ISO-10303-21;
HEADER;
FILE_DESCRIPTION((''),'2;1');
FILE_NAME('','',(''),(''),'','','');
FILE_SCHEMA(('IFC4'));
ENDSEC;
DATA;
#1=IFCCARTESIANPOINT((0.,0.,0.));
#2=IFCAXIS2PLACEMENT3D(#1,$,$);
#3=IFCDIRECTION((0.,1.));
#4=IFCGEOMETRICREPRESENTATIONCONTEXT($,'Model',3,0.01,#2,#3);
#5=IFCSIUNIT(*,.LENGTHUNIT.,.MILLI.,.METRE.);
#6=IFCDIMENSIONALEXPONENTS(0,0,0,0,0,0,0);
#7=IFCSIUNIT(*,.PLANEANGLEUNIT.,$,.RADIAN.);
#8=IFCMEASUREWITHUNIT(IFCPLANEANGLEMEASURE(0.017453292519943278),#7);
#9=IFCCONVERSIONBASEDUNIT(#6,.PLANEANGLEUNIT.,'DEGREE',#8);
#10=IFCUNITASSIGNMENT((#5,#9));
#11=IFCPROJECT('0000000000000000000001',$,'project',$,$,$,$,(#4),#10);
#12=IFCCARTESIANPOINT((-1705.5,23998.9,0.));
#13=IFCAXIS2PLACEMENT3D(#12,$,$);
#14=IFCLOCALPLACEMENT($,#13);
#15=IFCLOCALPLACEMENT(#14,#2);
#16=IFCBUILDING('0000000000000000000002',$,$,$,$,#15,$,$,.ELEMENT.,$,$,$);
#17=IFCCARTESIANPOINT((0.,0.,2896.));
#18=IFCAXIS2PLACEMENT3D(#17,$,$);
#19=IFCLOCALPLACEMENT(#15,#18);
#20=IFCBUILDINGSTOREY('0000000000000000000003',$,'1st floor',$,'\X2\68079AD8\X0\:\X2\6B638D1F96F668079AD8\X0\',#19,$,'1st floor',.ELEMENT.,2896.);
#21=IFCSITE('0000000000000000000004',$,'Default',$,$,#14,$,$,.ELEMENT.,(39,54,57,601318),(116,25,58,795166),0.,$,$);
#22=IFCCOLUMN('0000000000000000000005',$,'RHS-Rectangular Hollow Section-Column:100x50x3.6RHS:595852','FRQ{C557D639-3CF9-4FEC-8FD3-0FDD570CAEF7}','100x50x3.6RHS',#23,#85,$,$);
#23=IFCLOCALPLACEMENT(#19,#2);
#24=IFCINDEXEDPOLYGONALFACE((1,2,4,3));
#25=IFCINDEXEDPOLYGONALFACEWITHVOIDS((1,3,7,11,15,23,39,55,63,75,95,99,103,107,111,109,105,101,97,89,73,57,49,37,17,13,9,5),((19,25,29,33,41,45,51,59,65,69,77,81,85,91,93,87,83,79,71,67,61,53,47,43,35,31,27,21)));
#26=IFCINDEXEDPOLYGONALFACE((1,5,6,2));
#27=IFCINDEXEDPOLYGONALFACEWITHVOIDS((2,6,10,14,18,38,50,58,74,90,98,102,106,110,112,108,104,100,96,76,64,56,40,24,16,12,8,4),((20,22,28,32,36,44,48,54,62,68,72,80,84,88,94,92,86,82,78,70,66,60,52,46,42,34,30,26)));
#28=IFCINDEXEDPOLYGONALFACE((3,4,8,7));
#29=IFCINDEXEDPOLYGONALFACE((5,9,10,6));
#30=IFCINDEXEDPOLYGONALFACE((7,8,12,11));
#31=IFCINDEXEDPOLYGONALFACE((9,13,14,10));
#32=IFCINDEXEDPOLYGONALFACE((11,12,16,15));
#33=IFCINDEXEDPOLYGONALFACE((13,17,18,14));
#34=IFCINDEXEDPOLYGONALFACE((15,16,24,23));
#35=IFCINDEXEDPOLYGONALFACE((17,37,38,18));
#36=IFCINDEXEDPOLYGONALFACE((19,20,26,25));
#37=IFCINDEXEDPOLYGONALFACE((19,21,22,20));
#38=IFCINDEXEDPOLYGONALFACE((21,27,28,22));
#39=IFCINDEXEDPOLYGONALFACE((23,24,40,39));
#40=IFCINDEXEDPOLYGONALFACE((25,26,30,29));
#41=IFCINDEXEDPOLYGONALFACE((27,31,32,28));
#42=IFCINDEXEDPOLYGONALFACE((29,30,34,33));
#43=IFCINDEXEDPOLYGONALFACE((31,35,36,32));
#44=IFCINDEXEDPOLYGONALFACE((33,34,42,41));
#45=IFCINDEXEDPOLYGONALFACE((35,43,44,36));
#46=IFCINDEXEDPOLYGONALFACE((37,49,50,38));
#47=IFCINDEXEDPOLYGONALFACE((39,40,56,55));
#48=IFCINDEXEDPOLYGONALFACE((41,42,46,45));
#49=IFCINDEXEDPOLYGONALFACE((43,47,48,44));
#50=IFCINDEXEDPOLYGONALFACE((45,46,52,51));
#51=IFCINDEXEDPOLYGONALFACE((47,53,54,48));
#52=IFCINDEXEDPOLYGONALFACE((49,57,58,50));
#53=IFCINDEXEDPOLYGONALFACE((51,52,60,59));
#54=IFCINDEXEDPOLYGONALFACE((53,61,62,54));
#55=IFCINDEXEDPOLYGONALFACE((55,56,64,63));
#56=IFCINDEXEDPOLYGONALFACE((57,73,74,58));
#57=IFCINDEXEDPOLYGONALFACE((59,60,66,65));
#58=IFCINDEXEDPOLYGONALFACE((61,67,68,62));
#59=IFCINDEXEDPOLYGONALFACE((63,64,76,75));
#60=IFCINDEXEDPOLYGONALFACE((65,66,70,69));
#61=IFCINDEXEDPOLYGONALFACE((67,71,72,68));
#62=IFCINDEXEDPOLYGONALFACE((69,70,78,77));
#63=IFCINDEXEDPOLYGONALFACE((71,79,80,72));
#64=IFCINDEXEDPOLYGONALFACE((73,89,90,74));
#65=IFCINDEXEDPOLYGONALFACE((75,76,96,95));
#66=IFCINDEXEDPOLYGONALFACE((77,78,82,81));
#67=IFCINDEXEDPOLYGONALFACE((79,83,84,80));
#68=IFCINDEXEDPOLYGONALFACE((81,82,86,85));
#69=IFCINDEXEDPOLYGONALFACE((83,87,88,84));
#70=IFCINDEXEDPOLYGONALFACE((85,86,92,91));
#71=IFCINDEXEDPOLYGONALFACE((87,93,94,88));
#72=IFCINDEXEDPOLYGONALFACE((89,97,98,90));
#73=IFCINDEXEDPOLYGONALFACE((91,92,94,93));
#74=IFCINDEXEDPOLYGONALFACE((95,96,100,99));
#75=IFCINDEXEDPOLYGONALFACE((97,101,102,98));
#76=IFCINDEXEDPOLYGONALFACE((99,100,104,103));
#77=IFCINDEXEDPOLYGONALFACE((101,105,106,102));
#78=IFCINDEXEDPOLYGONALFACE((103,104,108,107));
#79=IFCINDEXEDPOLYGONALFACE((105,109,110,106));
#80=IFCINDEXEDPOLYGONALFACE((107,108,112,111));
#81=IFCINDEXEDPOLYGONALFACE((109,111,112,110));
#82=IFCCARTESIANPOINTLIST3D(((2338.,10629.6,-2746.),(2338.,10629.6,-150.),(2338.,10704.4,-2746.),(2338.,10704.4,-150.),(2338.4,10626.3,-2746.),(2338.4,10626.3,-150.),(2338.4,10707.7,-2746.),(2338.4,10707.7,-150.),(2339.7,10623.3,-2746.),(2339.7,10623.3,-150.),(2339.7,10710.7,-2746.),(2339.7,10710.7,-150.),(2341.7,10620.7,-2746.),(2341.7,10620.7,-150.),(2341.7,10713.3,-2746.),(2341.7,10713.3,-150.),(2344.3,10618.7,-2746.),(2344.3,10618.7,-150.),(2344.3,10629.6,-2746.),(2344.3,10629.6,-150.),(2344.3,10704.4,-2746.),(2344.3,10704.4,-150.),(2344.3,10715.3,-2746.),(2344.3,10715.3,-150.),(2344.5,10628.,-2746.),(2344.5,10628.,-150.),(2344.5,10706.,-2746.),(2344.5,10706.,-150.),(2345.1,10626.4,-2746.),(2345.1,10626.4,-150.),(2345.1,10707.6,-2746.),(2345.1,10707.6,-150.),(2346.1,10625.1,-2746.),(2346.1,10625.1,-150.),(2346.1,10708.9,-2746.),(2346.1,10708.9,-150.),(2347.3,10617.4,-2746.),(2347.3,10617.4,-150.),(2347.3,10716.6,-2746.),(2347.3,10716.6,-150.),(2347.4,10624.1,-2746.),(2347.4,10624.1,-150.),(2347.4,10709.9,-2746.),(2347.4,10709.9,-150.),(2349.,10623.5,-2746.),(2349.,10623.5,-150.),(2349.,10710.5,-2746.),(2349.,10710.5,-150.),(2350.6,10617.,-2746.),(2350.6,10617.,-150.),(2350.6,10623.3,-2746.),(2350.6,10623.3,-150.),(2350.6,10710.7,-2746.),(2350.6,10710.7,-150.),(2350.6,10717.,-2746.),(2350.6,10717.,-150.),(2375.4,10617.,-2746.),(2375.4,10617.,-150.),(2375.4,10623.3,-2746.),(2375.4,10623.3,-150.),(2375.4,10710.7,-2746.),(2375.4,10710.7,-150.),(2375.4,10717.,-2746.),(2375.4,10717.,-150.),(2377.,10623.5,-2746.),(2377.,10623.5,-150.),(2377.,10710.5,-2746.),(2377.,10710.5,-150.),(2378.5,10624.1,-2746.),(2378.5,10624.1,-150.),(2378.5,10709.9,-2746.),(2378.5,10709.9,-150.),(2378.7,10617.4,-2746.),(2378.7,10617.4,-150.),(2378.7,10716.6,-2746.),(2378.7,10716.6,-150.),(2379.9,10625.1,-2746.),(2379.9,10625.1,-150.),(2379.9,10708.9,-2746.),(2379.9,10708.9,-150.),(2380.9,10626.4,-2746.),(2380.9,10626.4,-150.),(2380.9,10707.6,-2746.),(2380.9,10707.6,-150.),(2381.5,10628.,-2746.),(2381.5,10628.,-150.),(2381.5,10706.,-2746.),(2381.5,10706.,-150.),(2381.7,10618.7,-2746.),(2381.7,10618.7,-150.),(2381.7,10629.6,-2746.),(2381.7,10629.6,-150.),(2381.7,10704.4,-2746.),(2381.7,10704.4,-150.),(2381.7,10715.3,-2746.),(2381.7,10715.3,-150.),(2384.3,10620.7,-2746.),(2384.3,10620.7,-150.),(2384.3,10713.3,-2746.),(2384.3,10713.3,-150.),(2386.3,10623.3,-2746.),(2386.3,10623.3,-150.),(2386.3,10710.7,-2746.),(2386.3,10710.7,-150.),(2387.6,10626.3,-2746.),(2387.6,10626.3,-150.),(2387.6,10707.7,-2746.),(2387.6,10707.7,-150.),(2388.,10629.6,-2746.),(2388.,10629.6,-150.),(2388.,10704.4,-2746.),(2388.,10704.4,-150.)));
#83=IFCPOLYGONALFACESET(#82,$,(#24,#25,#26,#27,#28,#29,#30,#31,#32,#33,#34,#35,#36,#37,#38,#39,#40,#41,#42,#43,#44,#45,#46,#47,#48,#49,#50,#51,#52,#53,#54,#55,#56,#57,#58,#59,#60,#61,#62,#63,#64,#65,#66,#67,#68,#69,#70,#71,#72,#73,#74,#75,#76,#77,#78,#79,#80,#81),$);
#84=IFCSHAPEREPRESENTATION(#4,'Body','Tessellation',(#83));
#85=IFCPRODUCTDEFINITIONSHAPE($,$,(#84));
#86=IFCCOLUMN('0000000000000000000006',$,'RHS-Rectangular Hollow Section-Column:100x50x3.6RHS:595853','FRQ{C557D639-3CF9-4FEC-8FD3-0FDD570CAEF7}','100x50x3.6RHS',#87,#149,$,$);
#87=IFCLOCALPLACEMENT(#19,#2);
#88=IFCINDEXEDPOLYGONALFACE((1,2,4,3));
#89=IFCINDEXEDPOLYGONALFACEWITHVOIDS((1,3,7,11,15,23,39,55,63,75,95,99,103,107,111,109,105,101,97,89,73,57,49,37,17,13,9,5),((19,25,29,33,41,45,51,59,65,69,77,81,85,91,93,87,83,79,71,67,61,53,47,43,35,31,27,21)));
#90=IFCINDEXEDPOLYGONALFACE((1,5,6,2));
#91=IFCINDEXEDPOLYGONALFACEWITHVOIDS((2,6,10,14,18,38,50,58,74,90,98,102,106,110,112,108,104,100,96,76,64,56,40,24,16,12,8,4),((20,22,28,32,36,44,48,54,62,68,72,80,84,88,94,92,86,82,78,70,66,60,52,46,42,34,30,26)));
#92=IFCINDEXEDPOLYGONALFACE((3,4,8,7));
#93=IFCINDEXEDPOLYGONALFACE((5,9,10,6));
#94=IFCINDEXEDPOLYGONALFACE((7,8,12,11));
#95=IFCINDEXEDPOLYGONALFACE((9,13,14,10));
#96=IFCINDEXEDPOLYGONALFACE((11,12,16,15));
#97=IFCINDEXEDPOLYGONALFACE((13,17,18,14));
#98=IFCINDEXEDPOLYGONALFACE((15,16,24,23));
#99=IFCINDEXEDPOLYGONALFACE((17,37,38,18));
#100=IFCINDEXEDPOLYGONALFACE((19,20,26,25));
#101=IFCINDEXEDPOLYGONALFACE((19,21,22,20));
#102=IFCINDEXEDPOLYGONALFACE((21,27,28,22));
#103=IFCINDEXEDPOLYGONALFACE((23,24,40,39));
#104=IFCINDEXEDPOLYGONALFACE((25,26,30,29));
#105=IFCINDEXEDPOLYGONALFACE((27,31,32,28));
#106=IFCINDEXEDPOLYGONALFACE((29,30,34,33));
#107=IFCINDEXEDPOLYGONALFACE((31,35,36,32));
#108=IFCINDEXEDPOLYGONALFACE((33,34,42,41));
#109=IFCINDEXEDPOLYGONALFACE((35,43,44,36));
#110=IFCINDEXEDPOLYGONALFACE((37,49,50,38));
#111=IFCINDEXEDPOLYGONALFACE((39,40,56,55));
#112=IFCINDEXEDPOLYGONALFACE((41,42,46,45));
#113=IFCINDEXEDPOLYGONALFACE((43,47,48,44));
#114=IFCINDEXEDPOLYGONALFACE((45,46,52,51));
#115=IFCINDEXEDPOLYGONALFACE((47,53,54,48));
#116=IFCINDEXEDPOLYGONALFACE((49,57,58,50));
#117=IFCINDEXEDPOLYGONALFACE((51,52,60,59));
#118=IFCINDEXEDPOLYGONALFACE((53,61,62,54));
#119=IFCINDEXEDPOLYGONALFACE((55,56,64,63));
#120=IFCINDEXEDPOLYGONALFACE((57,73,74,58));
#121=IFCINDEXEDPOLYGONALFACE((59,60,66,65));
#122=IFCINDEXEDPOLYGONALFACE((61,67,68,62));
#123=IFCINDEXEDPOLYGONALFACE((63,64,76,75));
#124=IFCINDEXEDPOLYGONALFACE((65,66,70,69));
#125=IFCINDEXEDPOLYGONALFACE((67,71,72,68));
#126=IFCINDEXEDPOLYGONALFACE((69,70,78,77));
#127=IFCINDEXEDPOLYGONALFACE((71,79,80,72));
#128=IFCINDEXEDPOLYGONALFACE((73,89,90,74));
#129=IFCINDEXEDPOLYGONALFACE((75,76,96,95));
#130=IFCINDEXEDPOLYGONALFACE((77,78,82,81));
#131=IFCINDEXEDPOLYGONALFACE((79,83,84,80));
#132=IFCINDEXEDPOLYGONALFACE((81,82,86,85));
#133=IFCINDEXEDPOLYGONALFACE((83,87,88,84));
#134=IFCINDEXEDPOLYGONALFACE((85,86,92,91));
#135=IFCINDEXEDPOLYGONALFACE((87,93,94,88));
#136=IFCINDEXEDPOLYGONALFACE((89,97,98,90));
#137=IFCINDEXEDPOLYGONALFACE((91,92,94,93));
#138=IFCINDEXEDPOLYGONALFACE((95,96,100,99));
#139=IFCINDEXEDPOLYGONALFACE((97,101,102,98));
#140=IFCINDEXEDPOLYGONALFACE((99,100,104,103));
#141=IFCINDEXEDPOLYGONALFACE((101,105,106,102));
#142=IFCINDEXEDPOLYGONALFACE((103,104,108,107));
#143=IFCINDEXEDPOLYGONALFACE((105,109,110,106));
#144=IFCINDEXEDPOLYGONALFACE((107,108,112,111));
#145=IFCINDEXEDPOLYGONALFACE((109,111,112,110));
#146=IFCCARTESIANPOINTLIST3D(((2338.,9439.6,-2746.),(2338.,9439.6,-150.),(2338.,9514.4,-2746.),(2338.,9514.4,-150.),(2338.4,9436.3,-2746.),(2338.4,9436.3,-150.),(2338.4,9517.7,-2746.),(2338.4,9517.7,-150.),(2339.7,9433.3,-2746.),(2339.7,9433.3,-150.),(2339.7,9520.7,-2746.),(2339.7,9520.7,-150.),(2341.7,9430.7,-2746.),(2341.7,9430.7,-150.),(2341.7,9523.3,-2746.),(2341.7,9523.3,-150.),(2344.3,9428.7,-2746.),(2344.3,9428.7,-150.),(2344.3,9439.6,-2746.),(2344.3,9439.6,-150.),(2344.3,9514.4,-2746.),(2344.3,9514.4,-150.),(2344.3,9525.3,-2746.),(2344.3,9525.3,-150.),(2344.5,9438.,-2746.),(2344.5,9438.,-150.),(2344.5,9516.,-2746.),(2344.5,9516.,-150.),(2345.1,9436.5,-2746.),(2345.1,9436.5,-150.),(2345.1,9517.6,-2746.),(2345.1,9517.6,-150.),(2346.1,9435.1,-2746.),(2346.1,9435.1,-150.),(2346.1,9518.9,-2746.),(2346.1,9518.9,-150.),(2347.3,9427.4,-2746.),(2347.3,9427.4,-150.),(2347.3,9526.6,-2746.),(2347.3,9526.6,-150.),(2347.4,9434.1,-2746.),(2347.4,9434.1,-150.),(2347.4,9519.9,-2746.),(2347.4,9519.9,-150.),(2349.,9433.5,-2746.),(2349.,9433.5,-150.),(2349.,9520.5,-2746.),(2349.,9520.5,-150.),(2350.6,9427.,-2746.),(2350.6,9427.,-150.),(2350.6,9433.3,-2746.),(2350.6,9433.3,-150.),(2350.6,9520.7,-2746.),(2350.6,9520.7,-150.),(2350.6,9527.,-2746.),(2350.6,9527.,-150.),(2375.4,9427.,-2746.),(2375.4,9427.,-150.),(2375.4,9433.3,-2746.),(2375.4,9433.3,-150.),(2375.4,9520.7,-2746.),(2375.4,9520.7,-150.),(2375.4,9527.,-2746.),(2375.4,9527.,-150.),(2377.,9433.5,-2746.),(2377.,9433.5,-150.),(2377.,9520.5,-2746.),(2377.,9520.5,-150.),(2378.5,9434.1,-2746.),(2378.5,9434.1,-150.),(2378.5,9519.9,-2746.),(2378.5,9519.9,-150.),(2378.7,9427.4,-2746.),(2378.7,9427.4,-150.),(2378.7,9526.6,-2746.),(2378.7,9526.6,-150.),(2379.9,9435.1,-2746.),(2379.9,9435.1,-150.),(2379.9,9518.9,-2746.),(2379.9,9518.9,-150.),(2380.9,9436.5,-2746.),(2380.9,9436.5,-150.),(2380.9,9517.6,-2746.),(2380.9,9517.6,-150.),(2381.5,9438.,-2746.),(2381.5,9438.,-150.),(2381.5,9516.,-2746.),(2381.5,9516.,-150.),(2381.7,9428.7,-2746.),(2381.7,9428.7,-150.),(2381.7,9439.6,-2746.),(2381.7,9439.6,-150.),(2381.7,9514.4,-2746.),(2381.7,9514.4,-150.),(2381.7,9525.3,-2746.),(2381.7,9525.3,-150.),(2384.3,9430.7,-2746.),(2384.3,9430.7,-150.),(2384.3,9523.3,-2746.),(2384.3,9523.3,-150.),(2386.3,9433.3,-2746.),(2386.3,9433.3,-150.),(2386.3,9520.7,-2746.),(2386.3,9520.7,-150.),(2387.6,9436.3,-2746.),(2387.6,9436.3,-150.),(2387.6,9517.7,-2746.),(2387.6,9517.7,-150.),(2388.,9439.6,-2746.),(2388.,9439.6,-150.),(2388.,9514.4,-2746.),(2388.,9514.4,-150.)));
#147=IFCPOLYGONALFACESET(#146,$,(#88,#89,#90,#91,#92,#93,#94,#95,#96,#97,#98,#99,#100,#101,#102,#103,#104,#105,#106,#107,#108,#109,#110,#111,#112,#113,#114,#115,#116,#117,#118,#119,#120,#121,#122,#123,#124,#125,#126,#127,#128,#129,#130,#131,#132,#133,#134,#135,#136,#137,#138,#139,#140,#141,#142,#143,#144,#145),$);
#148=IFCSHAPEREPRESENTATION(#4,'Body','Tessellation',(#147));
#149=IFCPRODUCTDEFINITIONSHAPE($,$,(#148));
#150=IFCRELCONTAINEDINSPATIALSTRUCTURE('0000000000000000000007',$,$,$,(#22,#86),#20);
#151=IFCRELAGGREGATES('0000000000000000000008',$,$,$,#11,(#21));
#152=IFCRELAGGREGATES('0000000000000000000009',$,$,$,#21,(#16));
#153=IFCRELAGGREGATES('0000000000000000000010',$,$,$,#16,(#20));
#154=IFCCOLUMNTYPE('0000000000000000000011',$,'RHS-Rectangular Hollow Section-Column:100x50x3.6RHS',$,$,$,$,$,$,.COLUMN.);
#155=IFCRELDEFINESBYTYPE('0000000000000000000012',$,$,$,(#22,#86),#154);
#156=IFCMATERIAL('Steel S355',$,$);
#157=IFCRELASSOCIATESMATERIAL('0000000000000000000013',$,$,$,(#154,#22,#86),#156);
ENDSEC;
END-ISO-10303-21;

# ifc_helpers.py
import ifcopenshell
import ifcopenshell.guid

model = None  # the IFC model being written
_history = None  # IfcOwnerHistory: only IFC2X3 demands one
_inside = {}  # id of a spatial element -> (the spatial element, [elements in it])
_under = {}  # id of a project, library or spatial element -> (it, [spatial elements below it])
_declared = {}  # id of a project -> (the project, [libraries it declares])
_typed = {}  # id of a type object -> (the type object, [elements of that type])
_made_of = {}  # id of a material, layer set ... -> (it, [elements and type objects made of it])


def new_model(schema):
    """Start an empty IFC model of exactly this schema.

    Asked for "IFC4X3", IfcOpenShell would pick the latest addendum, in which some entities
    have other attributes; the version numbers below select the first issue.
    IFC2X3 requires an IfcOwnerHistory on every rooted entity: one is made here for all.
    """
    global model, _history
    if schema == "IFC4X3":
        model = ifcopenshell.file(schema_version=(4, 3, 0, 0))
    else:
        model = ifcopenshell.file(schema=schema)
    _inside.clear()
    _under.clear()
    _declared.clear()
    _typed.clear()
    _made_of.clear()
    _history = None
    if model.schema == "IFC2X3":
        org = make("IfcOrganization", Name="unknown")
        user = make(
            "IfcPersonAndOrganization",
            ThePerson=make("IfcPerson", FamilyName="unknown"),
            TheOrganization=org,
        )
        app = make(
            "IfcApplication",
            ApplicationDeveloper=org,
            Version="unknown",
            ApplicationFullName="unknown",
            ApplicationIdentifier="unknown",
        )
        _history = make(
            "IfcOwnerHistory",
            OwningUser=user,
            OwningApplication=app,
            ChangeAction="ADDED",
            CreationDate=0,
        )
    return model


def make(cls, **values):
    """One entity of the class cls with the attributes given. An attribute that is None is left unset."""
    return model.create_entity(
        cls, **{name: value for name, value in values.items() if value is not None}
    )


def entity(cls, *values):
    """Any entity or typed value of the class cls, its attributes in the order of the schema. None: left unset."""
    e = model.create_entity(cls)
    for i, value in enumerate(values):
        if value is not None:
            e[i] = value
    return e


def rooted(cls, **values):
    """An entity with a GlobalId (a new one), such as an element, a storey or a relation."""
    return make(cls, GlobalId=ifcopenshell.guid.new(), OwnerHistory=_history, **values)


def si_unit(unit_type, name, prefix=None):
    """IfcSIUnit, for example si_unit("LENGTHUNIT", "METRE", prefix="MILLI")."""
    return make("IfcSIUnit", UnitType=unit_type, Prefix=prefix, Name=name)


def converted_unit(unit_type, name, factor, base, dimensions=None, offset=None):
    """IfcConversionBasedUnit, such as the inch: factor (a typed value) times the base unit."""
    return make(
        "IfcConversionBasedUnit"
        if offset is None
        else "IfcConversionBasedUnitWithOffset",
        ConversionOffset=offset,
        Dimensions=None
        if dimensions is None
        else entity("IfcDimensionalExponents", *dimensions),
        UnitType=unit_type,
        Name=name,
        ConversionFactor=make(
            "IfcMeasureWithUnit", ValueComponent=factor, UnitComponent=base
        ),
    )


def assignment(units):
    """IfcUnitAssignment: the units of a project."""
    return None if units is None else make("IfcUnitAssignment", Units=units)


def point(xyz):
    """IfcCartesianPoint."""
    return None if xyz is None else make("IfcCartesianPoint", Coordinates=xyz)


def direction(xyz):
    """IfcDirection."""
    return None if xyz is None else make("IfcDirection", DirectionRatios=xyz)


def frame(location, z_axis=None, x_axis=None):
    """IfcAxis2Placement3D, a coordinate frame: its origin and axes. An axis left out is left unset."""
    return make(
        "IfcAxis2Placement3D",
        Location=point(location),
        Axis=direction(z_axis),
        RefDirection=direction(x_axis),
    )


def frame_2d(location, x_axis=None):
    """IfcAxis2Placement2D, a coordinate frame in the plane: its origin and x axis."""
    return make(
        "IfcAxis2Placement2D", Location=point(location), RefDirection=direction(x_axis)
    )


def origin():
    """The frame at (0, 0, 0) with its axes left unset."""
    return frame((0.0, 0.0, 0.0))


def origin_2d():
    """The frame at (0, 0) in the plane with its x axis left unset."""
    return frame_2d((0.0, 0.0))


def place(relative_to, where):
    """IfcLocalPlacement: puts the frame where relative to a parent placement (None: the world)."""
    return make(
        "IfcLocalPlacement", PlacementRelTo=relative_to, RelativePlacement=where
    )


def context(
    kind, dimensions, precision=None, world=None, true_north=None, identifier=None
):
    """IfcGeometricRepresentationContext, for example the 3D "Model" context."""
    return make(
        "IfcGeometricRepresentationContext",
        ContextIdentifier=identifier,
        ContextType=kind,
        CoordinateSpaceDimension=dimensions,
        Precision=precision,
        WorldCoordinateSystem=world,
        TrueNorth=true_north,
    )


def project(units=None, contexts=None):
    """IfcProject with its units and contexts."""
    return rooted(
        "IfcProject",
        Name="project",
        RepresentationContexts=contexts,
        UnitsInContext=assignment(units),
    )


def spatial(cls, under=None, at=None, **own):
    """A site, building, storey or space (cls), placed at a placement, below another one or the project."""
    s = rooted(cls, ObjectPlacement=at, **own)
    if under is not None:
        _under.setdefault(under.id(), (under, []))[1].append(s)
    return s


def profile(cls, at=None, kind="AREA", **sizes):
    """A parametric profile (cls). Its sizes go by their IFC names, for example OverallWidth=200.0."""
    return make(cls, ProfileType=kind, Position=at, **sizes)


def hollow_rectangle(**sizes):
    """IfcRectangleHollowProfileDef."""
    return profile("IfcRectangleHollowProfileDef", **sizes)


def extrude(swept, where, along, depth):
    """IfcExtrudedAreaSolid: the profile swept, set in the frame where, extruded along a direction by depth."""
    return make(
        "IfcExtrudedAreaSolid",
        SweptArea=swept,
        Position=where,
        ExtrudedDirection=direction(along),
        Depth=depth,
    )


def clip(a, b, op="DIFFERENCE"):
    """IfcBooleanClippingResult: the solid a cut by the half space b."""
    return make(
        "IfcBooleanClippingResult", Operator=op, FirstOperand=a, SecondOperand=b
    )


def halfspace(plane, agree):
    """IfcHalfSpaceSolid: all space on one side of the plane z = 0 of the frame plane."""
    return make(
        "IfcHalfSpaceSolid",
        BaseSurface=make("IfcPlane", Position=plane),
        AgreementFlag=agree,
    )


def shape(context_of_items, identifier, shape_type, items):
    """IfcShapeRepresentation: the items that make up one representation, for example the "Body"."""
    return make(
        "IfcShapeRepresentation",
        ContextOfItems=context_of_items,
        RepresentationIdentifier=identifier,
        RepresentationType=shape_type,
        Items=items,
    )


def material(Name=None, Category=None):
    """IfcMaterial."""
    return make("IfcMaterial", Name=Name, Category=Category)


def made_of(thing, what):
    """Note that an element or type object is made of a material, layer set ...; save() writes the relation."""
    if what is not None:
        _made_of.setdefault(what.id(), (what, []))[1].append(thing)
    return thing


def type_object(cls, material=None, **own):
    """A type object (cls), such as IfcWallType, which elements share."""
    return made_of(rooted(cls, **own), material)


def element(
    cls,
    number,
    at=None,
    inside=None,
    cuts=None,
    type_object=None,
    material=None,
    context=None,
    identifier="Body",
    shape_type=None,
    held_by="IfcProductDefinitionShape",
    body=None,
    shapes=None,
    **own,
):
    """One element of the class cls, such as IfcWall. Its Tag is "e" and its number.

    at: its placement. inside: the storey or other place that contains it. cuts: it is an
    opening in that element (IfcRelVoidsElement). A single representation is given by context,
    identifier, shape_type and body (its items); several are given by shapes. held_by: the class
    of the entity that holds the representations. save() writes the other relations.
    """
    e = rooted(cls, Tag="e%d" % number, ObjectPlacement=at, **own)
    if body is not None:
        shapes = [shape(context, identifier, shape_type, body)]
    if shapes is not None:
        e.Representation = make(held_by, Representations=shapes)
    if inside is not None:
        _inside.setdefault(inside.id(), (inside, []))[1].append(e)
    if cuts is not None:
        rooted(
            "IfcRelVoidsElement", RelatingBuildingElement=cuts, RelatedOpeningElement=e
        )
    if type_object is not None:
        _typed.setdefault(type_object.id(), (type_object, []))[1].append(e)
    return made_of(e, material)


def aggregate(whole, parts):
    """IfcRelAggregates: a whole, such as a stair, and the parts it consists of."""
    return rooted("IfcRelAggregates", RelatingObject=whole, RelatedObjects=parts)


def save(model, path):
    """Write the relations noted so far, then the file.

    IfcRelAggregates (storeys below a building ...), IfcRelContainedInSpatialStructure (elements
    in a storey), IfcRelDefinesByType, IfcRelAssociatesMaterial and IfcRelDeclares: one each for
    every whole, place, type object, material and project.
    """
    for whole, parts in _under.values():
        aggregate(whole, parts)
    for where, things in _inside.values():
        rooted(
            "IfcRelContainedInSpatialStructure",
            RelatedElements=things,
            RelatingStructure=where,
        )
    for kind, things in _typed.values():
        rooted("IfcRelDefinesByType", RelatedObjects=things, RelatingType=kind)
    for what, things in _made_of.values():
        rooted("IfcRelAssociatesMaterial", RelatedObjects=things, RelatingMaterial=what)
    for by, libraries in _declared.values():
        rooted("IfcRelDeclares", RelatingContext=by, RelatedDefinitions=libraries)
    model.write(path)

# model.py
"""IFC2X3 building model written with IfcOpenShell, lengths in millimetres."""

from ifc_helpers import new_model, entity, si_unit, converted_unit, direction, frame, origin, origin_2d, place, context, project, spatial, hollow_rectangle, extrude, clip, halfspace, material, type_object, element, save


model = new_model("IFC2X3")

# Units and contexts
model_context = context("Model", 3, precision=0.01, world=origin(), true_north=direction((0.0, 1.0)))
ifc_project = project(units=[si_unit("LENGTHUNIT", "METRE", prefix="MILLI"), converted_unit("PLANEANGLEUNIT", "DEGREE", entity("IfcPlaneAngleMeasure", 0.017453292519943278), si_unit("PLANEANGLEUNIT", "RADIAN"), dimensions=[0, 0, 0, 0, 0, 0, 0])], contexts=[model_context])

# Site, building, storey
site_placement = place(None, frame((-1705.5, 23998.9, 0.0)))
site = spatial("IfcSite", under=ifc_project, at=site_placement, Name="Default", CompositionType="ELEMENT", RefLatitude=(39, 54, 57, 601318), RefLongitude=(116, 25, 58, 795166), RefElevation=0.0)
building_placement = place(site_placement, origin())
building = spatial("IfcBuilding", under=site, at=building_placement, CompositionType="ELEMENT")
storey_placement = place(building_placement, frame((0.0, 0.0, 2896.0)))
storey = spatial("IfcBuildingStorey", under=building, at=storey_placement, Name="1st floor", ObjectType="标高:正负零标高", LongName="1st floor", CompositionType="ELEMENT", Elevation=2896.0)

# Columns
ifc_material_1 = material(Name="Steel S355")
column_type = type_object("IfcColumnType", Name="RHS-Rectangular Hollow Section-Column:100x50x3.6RHS", PredefinedType="COLUMN", material=ifc_material_1)
column_1_placement = place(storey_placement, frame((2363.0, 10667.0, -150.0), z_axis=(0.0, 0.0, 1.0), x_axis=(-1.0, 0.0, 0.0)))
element("IfcColumn", 1, at=column_1_placement, inside=storey, type_object=column_type, material=ifc_material_1, Name="RHS-Rectangular Hollow Section-Column:100x50x3.6RHS:595852", Description="FRQ{C557D639-3CF9-4FEC-8FD3-0FDD570CAEF7}", ObjectType="100x50x3.6RHS", context=model_context, shape_type="Clipping", body=[
    clip(extrude(hollow_rectangle(XDim=50.0, YDim=100.0, WallThickness=6.3, InnerFilletRadius=6.3, OuterFilletRadius=12.6, at=origin_2d()), origin(), (0.0, 0.0, -1.0), 2651.9), halfspace(frame((2363.0, 10667.0, -2596.0), z_axis=(0.0, 0.0, 1.0), x_axis=(-1.0, 0.0, 0.0)), True)),
])
column_2_placement = place(storey_placement, frame((2363.0, 9477.0, -150.0), z_axis=(0.0, 0.0, 1.0), x_axis=(-1.0, 0.0, 0.0)))
element("IfcColumn", 2, at=column_2_placement, inside=storey, type_object=column_type, material=ifc_material_1, Name="RHS-Rectangular Hollow Section-Column:100x50x3.6RHS:595853", Description="FRQ{C557D639-3CF9-4FEC-8FD3-0FDD570CAEF7}", ObjectType="100x50x3.6RHS", context=model_context, shape_type="Clipping", body=[
    clip(extrude(hollow_rectangle(XDim=50.0, YDim=100.0, WallThickness=6.3, InnerFilletRadius=6.3, OuterFilletRadius=12.6, at=origin_2d()), origin(), (0.0, 0.0, -1.0), 2651.9), halfspace(frame((2363.0, 9477.0, -2596.0), z_axis=(0.0, 0.0, 1.0), x_axis=(-1.0, 0.0, 0.0)), True)),
])

save(model, "model.ifc")
